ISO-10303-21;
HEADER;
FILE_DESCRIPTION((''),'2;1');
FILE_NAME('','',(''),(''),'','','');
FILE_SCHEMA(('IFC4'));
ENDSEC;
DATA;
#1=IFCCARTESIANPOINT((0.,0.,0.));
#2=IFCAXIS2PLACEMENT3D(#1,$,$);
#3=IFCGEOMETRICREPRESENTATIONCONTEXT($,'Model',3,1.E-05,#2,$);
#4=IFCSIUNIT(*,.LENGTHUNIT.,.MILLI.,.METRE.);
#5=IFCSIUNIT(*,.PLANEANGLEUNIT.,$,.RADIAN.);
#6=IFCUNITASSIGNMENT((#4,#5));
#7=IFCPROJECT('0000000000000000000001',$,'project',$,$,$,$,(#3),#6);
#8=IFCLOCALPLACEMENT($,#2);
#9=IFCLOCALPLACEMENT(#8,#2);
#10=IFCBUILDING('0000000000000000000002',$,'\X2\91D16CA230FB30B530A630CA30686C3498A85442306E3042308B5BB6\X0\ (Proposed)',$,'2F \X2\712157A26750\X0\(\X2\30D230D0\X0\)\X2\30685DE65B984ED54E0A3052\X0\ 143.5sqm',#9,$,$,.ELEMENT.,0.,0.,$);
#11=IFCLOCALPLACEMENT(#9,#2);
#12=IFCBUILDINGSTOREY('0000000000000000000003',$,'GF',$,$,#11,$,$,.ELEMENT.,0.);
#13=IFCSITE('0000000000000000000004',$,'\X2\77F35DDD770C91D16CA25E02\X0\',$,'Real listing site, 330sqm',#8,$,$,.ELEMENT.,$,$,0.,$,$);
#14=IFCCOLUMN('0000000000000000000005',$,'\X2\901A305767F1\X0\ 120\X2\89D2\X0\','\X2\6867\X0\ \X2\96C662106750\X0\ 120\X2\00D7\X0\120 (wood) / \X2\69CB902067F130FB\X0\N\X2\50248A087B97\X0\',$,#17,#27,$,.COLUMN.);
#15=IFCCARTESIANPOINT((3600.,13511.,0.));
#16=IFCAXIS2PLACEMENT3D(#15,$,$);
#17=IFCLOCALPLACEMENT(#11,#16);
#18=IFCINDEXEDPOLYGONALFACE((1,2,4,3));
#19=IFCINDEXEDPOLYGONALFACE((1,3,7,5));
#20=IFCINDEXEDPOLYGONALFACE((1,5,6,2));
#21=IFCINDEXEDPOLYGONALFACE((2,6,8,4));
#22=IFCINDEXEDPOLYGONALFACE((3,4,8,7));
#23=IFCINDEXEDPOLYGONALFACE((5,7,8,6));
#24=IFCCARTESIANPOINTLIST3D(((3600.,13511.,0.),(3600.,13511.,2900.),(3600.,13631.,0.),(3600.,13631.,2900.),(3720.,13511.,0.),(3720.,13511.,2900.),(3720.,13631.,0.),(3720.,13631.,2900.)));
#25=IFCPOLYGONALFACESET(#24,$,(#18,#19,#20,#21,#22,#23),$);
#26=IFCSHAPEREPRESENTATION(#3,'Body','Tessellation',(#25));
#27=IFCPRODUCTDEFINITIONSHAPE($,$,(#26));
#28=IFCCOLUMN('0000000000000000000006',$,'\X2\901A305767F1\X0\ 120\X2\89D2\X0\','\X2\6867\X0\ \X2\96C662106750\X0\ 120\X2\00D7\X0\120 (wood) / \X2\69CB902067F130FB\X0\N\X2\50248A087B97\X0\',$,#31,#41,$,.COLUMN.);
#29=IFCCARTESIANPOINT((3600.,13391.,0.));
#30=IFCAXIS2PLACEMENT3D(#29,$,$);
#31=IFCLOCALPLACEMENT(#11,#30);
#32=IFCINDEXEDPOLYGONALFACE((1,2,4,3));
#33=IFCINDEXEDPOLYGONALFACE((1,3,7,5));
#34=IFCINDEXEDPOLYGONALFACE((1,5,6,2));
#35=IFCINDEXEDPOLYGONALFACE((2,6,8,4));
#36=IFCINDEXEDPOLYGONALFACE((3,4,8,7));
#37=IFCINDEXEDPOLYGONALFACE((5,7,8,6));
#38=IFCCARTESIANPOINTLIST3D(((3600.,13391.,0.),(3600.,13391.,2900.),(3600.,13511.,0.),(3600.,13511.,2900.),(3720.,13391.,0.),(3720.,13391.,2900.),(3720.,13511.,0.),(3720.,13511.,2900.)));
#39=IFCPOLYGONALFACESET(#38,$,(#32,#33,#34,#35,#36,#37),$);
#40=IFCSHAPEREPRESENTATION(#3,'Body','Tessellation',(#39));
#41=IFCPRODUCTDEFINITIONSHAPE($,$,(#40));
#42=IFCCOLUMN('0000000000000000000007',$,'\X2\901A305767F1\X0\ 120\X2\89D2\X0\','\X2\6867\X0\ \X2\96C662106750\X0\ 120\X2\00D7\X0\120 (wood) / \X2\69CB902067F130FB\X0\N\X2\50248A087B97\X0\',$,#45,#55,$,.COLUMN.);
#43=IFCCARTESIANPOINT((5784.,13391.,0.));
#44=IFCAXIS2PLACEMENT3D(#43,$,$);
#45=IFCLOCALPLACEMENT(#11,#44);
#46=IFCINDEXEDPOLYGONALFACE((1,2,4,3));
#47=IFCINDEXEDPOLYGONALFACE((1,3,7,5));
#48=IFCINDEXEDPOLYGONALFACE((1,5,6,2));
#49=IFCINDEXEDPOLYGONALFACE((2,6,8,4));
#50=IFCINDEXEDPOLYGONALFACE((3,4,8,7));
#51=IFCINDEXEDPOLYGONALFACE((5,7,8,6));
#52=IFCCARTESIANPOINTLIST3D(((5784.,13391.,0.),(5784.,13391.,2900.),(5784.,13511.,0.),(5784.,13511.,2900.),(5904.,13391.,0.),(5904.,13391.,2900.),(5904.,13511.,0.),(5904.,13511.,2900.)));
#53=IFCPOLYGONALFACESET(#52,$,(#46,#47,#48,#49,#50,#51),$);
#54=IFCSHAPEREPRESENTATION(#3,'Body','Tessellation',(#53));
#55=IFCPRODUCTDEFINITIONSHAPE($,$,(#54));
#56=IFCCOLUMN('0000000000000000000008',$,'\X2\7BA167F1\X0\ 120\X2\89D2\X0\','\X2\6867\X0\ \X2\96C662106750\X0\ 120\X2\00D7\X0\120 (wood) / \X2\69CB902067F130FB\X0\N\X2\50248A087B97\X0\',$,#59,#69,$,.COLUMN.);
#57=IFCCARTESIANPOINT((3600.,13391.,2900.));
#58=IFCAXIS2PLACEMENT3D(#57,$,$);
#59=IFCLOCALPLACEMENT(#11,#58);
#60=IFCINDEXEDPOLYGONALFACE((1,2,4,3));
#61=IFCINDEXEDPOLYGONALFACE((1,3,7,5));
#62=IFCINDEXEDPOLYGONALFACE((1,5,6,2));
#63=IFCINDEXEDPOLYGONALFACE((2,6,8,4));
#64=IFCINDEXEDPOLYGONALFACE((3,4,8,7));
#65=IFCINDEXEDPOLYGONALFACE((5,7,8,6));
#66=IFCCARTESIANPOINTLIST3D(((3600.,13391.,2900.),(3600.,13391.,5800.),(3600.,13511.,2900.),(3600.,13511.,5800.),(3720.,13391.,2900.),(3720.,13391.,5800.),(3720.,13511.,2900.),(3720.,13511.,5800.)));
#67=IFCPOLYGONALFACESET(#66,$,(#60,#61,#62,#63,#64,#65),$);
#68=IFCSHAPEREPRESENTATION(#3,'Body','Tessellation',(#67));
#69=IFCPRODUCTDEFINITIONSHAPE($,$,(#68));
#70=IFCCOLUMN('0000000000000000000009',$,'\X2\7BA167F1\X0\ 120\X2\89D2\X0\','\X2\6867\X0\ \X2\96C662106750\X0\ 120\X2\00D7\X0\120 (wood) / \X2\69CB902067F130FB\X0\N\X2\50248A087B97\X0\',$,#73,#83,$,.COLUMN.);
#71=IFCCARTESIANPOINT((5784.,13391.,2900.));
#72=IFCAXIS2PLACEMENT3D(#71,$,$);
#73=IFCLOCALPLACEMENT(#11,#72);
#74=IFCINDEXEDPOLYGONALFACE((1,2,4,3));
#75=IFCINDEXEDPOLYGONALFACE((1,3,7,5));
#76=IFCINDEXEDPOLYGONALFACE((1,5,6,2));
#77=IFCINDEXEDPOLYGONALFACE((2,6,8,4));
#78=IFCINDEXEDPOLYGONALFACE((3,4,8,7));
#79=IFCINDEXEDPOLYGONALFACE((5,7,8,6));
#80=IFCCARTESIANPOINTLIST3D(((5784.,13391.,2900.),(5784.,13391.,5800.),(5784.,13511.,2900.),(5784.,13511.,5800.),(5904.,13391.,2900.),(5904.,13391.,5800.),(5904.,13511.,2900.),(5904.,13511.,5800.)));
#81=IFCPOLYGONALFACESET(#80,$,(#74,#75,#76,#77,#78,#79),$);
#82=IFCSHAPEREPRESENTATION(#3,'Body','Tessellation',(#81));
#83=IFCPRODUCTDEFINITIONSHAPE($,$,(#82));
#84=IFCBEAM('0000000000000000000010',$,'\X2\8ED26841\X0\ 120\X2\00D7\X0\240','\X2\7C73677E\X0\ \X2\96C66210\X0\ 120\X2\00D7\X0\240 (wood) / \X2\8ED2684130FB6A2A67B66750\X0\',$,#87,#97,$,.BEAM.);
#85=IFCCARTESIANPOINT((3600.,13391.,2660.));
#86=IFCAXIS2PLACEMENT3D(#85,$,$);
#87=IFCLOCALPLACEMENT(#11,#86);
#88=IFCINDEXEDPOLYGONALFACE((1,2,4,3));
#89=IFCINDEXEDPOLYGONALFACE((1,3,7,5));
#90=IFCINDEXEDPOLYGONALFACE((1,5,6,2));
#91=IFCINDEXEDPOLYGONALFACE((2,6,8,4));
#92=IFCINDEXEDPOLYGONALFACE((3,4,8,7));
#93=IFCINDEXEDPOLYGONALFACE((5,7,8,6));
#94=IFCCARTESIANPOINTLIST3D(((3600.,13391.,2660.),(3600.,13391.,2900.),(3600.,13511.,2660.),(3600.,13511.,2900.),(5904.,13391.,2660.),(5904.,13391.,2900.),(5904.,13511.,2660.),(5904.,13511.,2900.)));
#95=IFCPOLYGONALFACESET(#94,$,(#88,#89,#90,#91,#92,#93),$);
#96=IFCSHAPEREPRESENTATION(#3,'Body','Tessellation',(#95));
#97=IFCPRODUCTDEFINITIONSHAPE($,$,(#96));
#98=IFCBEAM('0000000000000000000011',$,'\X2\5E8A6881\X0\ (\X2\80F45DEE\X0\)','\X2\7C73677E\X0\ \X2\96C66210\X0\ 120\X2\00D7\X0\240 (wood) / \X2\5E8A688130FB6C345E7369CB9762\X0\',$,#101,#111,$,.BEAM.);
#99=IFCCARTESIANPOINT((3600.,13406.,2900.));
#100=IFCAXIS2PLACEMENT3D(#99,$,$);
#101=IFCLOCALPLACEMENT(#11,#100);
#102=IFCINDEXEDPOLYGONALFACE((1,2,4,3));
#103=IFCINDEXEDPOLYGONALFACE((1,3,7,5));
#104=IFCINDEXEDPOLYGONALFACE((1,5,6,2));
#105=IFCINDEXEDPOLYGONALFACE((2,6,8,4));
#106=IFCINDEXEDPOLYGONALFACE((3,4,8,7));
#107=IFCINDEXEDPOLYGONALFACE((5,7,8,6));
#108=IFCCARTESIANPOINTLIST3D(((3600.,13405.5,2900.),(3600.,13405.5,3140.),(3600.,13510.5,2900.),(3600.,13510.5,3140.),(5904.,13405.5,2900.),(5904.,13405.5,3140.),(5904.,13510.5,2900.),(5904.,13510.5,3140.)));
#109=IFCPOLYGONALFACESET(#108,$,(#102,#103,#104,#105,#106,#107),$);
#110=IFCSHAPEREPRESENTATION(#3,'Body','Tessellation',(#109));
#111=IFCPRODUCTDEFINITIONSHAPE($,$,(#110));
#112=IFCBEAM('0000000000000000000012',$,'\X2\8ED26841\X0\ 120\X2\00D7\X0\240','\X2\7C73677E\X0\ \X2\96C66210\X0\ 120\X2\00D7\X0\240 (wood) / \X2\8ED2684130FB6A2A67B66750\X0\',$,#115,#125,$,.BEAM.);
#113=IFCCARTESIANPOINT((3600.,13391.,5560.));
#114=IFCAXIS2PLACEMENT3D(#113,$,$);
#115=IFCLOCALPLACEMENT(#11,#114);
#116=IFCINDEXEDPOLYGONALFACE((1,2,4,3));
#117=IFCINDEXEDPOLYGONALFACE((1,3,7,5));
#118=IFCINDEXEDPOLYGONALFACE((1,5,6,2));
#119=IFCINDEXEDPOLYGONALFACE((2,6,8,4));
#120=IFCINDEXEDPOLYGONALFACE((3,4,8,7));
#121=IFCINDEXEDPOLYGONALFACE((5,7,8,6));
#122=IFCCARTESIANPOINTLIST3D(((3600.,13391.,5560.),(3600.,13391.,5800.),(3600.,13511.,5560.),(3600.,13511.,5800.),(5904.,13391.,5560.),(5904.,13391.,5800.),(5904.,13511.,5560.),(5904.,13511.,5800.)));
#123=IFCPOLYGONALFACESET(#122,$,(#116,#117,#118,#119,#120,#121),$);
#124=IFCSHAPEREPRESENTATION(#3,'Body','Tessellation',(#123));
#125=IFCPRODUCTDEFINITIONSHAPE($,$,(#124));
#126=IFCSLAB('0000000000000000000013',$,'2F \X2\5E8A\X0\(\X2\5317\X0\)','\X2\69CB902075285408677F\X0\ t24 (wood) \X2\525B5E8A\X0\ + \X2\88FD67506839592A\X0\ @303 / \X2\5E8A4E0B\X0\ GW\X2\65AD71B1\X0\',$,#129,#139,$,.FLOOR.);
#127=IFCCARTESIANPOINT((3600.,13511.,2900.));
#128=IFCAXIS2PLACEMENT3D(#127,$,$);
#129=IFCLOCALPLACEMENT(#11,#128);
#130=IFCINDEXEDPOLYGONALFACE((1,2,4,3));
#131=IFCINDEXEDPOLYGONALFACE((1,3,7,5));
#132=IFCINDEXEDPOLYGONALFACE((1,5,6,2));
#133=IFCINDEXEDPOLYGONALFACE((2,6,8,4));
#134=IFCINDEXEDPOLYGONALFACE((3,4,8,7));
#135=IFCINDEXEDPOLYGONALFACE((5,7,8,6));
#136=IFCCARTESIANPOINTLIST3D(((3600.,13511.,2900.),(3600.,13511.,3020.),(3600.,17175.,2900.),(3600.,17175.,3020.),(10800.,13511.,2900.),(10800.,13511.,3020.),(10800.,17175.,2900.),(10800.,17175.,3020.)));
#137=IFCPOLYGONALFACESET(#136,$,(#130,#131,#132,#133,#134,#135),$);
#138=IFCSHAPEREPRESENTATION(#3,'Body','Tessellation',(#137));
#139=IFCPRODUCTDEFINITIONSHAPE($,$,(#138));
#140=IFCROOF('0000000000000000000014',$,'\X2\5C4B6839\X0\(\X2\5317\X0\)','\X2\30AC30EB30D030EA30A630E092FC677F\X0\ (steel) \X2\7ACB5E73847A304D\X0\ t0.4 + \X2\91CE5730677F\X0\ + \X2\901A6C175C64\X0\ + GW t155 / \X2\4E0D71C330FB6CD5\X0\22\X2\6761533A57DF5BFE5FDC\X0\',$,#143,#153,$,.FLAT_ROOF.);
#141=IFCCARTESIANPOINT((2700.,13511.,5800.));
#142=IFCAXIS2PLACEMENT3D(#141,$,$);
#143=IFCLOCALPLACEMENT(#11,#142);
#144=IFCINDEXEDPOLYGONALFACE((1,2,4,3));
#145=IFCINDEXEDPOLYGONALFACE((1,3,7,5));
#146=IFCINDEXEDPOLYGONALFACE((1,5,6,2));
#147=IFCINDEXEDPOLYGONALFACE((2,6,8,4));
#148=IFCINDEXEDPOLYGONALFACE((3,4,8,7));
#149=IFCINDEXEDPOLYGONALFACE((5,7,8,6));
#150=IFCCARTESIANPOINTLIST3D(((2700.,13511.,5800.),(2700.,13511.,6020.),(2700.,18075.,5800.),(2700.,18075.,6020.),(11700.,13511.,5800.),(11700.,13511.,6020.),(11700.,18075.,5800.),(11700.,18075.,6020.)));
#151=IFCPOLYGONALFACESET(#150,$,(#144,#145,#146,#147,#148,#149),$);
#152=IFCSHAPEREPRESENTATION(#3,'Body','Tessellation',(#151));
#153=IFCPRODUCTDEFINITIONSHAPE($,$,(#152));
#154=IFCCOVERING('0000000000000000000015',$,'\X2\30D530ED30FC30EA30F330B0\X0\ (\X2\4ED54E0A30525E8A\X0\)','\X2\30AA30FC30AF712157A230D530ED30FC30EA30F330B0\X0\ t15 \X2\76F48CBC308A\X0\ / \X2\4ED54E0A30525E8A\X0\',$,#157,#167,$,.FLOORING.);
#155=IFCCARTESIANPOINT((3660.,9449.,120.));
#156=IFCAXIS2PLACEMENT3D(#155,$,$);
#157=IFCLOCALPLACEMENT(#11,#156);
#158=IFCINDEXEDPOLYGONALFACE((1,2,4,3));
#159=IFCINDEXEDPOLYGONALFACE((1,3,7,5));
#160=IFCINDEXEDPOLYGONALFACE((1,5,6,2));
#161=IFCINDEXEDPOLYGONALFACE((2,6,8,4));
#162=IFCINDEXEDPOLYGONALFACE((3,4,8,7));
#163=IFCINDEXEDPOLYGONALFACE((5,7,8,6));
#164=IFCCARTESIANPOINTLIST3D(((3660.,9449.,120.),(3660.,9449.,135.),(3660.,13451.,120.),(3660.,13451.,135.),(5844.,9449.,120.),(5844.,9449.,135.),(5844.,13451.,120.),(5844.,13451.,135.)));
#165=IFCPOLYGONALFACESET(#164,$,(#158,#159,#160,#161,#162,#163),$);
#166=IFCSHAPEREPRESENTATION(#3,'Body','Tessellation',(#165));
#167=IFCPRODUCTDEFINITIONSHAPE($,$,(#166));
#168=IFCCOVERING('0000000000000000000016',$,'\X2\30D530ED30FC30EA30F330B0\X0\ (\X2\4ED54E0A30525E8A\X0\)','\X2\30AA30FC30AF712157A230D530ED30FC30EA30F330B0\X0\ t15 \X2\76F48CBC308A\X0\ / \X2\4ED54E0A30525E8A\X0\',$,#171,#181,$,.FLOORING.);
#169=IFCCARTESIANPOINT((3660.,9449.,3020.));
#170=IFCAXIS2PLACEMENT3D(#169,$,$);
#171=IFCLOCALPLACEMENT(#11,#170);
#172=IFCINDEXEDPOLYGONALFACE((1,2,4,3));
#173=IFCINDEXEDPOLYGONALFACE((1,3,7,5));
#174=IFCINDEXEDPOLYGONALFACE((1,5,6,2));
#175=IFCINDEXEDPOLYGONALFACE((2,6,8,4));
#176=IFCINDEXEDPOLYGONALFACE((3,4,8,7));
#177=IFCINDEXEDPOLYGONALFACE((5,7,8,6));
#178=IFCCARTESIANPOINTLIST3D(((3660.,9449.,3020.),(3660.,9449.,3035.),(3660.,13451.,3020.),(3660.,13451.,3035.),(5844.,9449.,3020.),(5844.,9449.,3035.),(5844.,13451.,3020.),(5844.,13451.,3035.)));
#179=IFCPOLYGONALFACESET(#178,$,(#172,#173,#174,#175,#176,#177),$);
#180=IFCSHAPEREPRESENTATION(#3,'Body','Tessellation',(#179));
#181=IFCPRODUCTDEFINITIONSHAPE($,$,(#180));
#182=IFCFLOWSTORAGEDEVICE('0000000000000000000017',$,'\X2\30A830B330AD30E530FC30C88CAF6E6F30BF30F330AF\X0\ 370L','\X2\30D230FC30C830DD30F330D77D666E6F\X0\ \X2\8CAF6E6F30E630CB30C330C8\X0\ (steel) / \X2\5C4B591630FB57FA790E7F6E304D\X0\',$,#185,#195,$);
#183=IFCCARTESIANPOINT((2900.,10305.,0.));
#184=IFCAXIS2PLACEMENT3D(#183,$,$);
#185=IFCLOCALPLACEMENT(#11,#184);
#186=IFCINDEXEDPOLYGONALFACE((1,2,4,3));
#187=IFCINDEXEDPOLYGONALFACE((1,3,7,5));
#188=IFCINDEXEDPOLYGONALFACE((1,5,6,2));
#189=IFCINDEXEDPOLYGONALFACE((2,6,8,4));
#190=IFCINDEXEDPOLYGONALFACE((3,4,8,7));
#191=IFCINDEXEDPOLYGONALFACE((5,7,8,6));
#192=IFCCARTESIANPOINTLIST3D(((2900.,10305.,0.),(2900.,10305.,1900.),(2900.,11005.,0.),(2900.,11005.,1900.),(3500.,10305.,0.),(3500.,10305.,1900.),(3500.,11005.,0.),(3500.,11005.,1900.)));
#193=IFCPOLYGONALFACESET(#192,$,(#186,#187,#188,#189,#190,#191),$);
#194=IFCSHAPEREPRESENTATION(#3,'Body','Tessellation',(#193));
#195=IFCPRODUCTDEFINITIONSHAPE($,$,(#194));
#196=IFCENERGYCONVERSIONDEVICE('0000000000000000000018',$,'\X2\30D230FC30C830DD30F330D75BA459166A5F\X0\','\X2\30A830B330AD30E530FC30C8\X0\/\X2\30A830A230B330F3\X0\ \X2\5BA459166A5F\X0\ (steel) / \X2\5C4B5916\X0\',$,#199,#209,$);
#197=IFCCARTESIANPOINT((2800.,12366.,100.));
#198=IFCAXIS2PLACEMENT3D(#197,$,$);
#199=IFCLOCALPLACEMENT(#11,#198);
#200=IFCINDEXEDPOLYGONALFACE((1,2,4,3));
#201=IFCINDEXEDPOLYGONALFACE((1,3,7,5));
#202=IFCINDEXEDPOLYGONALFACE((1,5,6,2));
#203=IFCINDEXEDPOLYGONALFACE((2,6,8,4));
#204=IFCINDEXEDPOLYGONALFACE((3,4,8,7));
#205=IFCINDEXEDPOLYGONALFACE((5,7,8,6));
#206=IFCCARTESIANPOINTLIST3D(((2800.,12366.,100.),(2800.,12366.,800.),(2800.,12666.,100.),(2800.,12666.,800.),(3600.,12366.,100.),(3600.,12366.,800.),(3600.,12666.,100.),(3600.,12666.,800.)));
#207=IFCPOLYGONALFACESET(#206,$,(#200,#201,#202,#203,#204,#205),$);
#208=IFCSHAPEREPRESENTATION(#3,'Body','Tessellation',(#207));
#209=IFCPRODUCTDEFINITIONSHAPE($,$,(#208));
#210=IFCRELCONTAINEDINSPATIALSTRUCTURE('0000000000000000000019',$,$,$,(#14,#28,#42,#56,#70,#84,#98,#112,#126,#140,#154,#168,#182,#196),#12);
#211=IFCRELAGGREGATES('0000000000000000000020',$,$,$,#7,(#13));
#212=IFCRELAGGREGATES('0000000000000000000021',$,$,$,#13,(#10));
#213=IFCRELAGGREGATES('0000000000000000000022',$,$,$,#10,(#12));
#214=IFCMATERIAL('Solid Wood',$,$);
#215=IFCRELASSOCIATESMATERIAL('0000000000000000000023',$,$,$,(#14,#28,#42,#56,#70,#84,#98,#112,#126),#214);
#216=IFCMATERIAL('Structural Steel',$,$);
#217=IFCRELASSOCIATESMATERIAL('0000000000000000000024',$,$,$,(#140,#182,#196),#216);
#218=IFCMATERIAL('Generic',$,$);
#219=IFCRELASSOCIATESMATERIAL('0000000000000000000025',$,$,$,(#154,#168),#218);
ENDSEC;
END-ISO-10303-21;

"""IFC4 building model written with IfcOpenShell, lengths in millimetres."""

from ifc_helpers import new_model, si_unit, frame, frame_2d, origin, place, context, project, spatial, rectangle, extrude, material, element, save


model = new_model("IFC4")

# Units and contexts
model_context = context("Model", 3, precision=1e-05, world=origin())
ifc_project = project(units=[si_unit("LENGTHUNIT", "METRE", prefix="MILLI"), si_unit("PLANEANGLEUNIT", "RADIAN")], contexts=[model_context])

# Site, building, storey
site_placement = place(None, origin())
site = spatial("IfcSite", under=ifc_project, at=site_placement, Name="石川県金沢市", ObjectType="Real listing site, 330sqm", CompositionType="ELEMENT", RefElevation=0.0)
building_placement = place(site_placement, origin())
building = spatial("IfcBuilding", under=site, at=building_placement, Name="金沢・サウナと水風呂のある家 (Proposed)", ObjectType="2F 無垢材(ヒバ)と左官仕上げ 143.5sqm", CompositionType="ELEMENT", ElevationOfRefHeight=0.0, ElevationOfTerrain=0.0)
storey_placement = place(building_placement, origin())
storey = spatial("IfcBuildingStorey", under=building, at=storey_placement, Name="GF", CompositionType="ELEMENT", Elevation=0.0)

# Columns
ifc_material_1 = material(Name="Solid Wood")
column_1_placement = place(storey_placement, frame((3600.0, 13511.0, 0.0)))
element("IfcColumn", 1, at=column_1_placement, inside=storey, material=ifc_material_1, Name="通し柱 120角", Description="桧 集成材 120×120 (wood) / 構造柱・N値計算", PredefinedType="COLUMN", context=model_context, shape_type="SweptSolid", body=[
    extrude(rectangle(XDim=120.0, YDim=120.0, at=frame_2d((60.0, 60.0))), frame((3600.0, 13511.0, 0.0)), (0.0, 0.0, 1.0), 2900.0),
])
column_2_placement = place(storey_placement, frame((3600.0, 13391.0, 0.0)))
element("IfcColumn", 2, at=column_2_placement, inside=storey, material=ifc_material_1, Name="通し柱 120角", Description="桧 集成材 120×120 (wood) / 構造柱・N値計算", PredefinedType="COLUMN", context=model_context, shape_type="SweptSolid", body=[
    extrude(rectangle(XDim=120.0, YDim=120.0, at=frame_2d((60.0, 60.0))), frame((3600.0, 13391.0, 0.0)), (0.0, 0.0, 1.0), 2900.0),
])
column_3_placement = place(storey_placement, frame((5784.0, 13391.0, 0.0)))
element("IfcColumn", 3, at=column_3_placement, inside=storey, material=ifc_material_1, Name="通し柱 120角", Description="桧 集成材 120×120 (wood) / 構造柱・N値計算", PredefinedType="COLUMN", context=model_context, shape_type="SweptSolid", body=[
    extrude(rectangle(XDim=120.0, YDim=120.0, at=frame_2d((60.0, 60.0))), frame((5784.0, 13391.0, 0.0)), (0.0, 0.0, 1.0), 2900.0),
])
column_4_placement = place(storey_placement, frame((3600.0, 13391.0, 2900.0)))
element("IfcColumn", 4, at=column_4_placement, inside=storey, material=ifc_material_1, Name="管柱 120角", Description="桧 集成材 120×120 (wood) / 構造柱・N値計算", PredefinedType="COLUMN", context=model_context, shape_type="SweptSolid", body=[
    extrude(rectangle(XDim=120.0, YDim=120.0, at=frame_2d((60.0, 60.0))), frame((3600.0, 13391.0, 2900.0)), (0.0, 0.0, 1.0), 2900.0),
])
column_5_placement = place(storey_placement, frame((5784.0, 13391.0, 2900.0)))
element("IfcColumn", 5, at=column_5_placement, inside=storey, material=ifc_material_1, Name="管柱 120角", Description="桧 集成材 120×120 (wood) / 構造柱・N値計算", PredefinedType="COLUMN", context=model_context, shape_type="SweptSolid", body=[
    extrude(rectangle(XDim=120.0, YDim=120.0, at=frame_2d((60.0, 60.0))), frame((5784.0, 13391.0, 2900.0)), (0.0, 0.0, 1.0), 2900.0),
])

# Beams
beam_1_placement = place(storey_placement, frame((3600.0, 13391.0, 2660.0)))
element("IfcBeam", 6, at=beam_1_placement, inside=storey, material=ifc_material_1, Name="軒桁 120×240", Description="米松 集成 120×240 (wood) / 軒桁・横架材", PredefinedType="BEAM", context=model_context, shape_type="SweptSolid", body=[
    extrude(rectangle(XDim=2304.0, YDim=120.0, at=frame_2d((1152.0, 60.0))), frame((3600.0, 13391.0, 2660.0)), (0.0, 0.0, 1.0), 240.0),
])
beam_2_placement = place(storey_placement, frame((3600.0, 13406.0, 2900.0)))
element("IfcBeam", 7, at=beam_2_placement, inside=storey, material=ifc_material_1, Name="床梁 (胴差)", Description="米松 集成 120×240 (wood) / 床梁・水平構面", PredefinedType="BEAM", context=model_context, shape_type="SweptSolid", body=[
    extrude(rectangle(XDim=2304.0, YDim=105.0, at=frame_2d((1152.0, 52.0))), frame((3600.0, 13406.0, 2900.0)), (0.0, 0.0, 1.0), 240.0),
])
beam_3_placement = place(storey_placement, frame((3600.0, 13391.0, 5560.0)))
element("IfcBeam", 8, at=beam_3_placement, inside=storey, material=ifc_material_1, Name="軒桁 120×240", Description="米松 集成 120×240 (wood) / 軒桁・横架材", PredefinedType="BEAM", context=model_context, shape_type="SweptSolid", body=[
    extrude(rectangle(XDim=2304.0, YDim=120.0, at=frame_2d((1152.0, 60.0))), frame((3600.0, 13391.0, 5560.0)), (0.0, 0.0, 1.0), 240.0),
])

# Slab
slab_1_placement = place(storey_placement, frame((3600.0, 13511.0, 2900.0)))
element("IfcSlab", 9, at=slab_1_placement, inside=storey, material=ifc_material_1, Name="2F 床(北)", Description="構造用合板 t24 (wood) 剛床 + 製材根太 @303 / 床下 GW断熱", PredefinedType="FLOOR", context=model_context, shape_type="SweptSolid", body=[
    extrude(rectangle(XDim=7200.0, YDim=3664.0, at=frame_2d((3600.0, 1832.0))), frame((3600.0, 13511.0, 2900.0)), (0.0, 0.0, 1.0), 120.0),
])

# Roof
ifc_material_2 = material(Name="Structural Steel")
for number, where, name in (
    (10, (2700.0, 13511.0, 5800.0), "屋根(北)"),
):
    element("IfcRoof", number, at=place(storey_placement, frame(where)), inside=storey, material=ifc_material_2, Name=name, Description="ガルバリウム鋼板 (steel) 立平葺き t0.4 + 野地板 + 通気層 + GW t155 / 不燃・法22条区域対応", PredefinedType="FLAT_ROOF", context=model_context, shape_type="SweptSolid", body=[
        extrude(rectangle(XDim=9000.0, YDim=4564.0, at=frame_2d((4500.0, 2282.0))), frame((2700.0, 13511.0, 5800.0)), (0.0, 0.0, 1.0), 220.0),
    ])

# Coverings
ifc_material_3 = material(Name="Generic")
covering_1_placement = place(storey_placement, frame((3660.0, 9449.0, 120.0)))
element("IfcCovering", 11, at=covering_1_placement, inside=storey, material=ifc_material_3, Name="フローリング (仕上げ床)", Description="オーク無垢フローリング t15 直貼り / 仕上げ床", PredefinedType="FLOORING", context=model_context, shape_type="SweptSolid", body=[
    extrude(rectangle(XDim=2184.0, YDim=4002.0, at=frame_2d((1092.0, 2001.0))), frame((3660.0, 9449.0, 120.0)), (0.0, 0.0, 1.0), 15.0),
])
covering_2_placement = place(storey_placement, frame((3660.0, 9449.0, 3020.0)))
element("IfcCovering", 12, at=covering_2_placement, inside=storey, material=ifc_material_3, Name="フローリング (仕上げ床)", Description="オーク無垢フローリング t15 直貼り / 仕上げ床", PredefinedType="FLOORING", context=model_context, shape_type="SweptSolid", body=[
    extrude(rectangle(XDim=2184.0, YDim=4002.0, at=frame_2d((1092.0, 2001.0))), frame((3660.0, 9449.0, 3020.0)), (0.0, 0.0, 1.0), 15.0),
])

# Flow storage device
flow_storage_device_placement = place(storey_placement, frame((2900.0, 10305.0, 0.0)))
element("IfcFlowStorageDevice", 13, at=flow_storage_device_placement, inside=storey, material=ifc_material_2, Name="エコキュート貯湯タンク 370L", Description="ヒートポンプ給湯 貯湯ユニット (steel) / 屋外・基礎置き", context=model_context, shape_type="SweptSolid", body=[
    extrude(rectangle(XDim=600.0, YDim=700.0, at=frame_2d((300.0, 350.0))), frame((2900.0, 10305.0, 0.0)), (0.0, 0.0, 1.0), 1900.0),
])

# Energy conversion device
energy_conversion_device_placement = place(storey_placement, frame((2800.0, 12366.0, 100.0)))
element("IfcEnergyConversionDevice", 14, at=energy_conversion_device_placement, inside=storey, material=ifc_material_2, Name="ヒートポンプ室外機", Description="エコキュート/エアコン 室外機 (steel) / 屋外", context=model_context, shape_type="SweptSolid", body=[
    extrude(rectangle(XDim=800.0, YDim=300.0, at=frame_2d((400.0, 150.0))), frame((2800.0, 12366.0, 100.0)), (0.0, 0.0, 1.0), 700.0),
])

save(model, "model.ifc")
